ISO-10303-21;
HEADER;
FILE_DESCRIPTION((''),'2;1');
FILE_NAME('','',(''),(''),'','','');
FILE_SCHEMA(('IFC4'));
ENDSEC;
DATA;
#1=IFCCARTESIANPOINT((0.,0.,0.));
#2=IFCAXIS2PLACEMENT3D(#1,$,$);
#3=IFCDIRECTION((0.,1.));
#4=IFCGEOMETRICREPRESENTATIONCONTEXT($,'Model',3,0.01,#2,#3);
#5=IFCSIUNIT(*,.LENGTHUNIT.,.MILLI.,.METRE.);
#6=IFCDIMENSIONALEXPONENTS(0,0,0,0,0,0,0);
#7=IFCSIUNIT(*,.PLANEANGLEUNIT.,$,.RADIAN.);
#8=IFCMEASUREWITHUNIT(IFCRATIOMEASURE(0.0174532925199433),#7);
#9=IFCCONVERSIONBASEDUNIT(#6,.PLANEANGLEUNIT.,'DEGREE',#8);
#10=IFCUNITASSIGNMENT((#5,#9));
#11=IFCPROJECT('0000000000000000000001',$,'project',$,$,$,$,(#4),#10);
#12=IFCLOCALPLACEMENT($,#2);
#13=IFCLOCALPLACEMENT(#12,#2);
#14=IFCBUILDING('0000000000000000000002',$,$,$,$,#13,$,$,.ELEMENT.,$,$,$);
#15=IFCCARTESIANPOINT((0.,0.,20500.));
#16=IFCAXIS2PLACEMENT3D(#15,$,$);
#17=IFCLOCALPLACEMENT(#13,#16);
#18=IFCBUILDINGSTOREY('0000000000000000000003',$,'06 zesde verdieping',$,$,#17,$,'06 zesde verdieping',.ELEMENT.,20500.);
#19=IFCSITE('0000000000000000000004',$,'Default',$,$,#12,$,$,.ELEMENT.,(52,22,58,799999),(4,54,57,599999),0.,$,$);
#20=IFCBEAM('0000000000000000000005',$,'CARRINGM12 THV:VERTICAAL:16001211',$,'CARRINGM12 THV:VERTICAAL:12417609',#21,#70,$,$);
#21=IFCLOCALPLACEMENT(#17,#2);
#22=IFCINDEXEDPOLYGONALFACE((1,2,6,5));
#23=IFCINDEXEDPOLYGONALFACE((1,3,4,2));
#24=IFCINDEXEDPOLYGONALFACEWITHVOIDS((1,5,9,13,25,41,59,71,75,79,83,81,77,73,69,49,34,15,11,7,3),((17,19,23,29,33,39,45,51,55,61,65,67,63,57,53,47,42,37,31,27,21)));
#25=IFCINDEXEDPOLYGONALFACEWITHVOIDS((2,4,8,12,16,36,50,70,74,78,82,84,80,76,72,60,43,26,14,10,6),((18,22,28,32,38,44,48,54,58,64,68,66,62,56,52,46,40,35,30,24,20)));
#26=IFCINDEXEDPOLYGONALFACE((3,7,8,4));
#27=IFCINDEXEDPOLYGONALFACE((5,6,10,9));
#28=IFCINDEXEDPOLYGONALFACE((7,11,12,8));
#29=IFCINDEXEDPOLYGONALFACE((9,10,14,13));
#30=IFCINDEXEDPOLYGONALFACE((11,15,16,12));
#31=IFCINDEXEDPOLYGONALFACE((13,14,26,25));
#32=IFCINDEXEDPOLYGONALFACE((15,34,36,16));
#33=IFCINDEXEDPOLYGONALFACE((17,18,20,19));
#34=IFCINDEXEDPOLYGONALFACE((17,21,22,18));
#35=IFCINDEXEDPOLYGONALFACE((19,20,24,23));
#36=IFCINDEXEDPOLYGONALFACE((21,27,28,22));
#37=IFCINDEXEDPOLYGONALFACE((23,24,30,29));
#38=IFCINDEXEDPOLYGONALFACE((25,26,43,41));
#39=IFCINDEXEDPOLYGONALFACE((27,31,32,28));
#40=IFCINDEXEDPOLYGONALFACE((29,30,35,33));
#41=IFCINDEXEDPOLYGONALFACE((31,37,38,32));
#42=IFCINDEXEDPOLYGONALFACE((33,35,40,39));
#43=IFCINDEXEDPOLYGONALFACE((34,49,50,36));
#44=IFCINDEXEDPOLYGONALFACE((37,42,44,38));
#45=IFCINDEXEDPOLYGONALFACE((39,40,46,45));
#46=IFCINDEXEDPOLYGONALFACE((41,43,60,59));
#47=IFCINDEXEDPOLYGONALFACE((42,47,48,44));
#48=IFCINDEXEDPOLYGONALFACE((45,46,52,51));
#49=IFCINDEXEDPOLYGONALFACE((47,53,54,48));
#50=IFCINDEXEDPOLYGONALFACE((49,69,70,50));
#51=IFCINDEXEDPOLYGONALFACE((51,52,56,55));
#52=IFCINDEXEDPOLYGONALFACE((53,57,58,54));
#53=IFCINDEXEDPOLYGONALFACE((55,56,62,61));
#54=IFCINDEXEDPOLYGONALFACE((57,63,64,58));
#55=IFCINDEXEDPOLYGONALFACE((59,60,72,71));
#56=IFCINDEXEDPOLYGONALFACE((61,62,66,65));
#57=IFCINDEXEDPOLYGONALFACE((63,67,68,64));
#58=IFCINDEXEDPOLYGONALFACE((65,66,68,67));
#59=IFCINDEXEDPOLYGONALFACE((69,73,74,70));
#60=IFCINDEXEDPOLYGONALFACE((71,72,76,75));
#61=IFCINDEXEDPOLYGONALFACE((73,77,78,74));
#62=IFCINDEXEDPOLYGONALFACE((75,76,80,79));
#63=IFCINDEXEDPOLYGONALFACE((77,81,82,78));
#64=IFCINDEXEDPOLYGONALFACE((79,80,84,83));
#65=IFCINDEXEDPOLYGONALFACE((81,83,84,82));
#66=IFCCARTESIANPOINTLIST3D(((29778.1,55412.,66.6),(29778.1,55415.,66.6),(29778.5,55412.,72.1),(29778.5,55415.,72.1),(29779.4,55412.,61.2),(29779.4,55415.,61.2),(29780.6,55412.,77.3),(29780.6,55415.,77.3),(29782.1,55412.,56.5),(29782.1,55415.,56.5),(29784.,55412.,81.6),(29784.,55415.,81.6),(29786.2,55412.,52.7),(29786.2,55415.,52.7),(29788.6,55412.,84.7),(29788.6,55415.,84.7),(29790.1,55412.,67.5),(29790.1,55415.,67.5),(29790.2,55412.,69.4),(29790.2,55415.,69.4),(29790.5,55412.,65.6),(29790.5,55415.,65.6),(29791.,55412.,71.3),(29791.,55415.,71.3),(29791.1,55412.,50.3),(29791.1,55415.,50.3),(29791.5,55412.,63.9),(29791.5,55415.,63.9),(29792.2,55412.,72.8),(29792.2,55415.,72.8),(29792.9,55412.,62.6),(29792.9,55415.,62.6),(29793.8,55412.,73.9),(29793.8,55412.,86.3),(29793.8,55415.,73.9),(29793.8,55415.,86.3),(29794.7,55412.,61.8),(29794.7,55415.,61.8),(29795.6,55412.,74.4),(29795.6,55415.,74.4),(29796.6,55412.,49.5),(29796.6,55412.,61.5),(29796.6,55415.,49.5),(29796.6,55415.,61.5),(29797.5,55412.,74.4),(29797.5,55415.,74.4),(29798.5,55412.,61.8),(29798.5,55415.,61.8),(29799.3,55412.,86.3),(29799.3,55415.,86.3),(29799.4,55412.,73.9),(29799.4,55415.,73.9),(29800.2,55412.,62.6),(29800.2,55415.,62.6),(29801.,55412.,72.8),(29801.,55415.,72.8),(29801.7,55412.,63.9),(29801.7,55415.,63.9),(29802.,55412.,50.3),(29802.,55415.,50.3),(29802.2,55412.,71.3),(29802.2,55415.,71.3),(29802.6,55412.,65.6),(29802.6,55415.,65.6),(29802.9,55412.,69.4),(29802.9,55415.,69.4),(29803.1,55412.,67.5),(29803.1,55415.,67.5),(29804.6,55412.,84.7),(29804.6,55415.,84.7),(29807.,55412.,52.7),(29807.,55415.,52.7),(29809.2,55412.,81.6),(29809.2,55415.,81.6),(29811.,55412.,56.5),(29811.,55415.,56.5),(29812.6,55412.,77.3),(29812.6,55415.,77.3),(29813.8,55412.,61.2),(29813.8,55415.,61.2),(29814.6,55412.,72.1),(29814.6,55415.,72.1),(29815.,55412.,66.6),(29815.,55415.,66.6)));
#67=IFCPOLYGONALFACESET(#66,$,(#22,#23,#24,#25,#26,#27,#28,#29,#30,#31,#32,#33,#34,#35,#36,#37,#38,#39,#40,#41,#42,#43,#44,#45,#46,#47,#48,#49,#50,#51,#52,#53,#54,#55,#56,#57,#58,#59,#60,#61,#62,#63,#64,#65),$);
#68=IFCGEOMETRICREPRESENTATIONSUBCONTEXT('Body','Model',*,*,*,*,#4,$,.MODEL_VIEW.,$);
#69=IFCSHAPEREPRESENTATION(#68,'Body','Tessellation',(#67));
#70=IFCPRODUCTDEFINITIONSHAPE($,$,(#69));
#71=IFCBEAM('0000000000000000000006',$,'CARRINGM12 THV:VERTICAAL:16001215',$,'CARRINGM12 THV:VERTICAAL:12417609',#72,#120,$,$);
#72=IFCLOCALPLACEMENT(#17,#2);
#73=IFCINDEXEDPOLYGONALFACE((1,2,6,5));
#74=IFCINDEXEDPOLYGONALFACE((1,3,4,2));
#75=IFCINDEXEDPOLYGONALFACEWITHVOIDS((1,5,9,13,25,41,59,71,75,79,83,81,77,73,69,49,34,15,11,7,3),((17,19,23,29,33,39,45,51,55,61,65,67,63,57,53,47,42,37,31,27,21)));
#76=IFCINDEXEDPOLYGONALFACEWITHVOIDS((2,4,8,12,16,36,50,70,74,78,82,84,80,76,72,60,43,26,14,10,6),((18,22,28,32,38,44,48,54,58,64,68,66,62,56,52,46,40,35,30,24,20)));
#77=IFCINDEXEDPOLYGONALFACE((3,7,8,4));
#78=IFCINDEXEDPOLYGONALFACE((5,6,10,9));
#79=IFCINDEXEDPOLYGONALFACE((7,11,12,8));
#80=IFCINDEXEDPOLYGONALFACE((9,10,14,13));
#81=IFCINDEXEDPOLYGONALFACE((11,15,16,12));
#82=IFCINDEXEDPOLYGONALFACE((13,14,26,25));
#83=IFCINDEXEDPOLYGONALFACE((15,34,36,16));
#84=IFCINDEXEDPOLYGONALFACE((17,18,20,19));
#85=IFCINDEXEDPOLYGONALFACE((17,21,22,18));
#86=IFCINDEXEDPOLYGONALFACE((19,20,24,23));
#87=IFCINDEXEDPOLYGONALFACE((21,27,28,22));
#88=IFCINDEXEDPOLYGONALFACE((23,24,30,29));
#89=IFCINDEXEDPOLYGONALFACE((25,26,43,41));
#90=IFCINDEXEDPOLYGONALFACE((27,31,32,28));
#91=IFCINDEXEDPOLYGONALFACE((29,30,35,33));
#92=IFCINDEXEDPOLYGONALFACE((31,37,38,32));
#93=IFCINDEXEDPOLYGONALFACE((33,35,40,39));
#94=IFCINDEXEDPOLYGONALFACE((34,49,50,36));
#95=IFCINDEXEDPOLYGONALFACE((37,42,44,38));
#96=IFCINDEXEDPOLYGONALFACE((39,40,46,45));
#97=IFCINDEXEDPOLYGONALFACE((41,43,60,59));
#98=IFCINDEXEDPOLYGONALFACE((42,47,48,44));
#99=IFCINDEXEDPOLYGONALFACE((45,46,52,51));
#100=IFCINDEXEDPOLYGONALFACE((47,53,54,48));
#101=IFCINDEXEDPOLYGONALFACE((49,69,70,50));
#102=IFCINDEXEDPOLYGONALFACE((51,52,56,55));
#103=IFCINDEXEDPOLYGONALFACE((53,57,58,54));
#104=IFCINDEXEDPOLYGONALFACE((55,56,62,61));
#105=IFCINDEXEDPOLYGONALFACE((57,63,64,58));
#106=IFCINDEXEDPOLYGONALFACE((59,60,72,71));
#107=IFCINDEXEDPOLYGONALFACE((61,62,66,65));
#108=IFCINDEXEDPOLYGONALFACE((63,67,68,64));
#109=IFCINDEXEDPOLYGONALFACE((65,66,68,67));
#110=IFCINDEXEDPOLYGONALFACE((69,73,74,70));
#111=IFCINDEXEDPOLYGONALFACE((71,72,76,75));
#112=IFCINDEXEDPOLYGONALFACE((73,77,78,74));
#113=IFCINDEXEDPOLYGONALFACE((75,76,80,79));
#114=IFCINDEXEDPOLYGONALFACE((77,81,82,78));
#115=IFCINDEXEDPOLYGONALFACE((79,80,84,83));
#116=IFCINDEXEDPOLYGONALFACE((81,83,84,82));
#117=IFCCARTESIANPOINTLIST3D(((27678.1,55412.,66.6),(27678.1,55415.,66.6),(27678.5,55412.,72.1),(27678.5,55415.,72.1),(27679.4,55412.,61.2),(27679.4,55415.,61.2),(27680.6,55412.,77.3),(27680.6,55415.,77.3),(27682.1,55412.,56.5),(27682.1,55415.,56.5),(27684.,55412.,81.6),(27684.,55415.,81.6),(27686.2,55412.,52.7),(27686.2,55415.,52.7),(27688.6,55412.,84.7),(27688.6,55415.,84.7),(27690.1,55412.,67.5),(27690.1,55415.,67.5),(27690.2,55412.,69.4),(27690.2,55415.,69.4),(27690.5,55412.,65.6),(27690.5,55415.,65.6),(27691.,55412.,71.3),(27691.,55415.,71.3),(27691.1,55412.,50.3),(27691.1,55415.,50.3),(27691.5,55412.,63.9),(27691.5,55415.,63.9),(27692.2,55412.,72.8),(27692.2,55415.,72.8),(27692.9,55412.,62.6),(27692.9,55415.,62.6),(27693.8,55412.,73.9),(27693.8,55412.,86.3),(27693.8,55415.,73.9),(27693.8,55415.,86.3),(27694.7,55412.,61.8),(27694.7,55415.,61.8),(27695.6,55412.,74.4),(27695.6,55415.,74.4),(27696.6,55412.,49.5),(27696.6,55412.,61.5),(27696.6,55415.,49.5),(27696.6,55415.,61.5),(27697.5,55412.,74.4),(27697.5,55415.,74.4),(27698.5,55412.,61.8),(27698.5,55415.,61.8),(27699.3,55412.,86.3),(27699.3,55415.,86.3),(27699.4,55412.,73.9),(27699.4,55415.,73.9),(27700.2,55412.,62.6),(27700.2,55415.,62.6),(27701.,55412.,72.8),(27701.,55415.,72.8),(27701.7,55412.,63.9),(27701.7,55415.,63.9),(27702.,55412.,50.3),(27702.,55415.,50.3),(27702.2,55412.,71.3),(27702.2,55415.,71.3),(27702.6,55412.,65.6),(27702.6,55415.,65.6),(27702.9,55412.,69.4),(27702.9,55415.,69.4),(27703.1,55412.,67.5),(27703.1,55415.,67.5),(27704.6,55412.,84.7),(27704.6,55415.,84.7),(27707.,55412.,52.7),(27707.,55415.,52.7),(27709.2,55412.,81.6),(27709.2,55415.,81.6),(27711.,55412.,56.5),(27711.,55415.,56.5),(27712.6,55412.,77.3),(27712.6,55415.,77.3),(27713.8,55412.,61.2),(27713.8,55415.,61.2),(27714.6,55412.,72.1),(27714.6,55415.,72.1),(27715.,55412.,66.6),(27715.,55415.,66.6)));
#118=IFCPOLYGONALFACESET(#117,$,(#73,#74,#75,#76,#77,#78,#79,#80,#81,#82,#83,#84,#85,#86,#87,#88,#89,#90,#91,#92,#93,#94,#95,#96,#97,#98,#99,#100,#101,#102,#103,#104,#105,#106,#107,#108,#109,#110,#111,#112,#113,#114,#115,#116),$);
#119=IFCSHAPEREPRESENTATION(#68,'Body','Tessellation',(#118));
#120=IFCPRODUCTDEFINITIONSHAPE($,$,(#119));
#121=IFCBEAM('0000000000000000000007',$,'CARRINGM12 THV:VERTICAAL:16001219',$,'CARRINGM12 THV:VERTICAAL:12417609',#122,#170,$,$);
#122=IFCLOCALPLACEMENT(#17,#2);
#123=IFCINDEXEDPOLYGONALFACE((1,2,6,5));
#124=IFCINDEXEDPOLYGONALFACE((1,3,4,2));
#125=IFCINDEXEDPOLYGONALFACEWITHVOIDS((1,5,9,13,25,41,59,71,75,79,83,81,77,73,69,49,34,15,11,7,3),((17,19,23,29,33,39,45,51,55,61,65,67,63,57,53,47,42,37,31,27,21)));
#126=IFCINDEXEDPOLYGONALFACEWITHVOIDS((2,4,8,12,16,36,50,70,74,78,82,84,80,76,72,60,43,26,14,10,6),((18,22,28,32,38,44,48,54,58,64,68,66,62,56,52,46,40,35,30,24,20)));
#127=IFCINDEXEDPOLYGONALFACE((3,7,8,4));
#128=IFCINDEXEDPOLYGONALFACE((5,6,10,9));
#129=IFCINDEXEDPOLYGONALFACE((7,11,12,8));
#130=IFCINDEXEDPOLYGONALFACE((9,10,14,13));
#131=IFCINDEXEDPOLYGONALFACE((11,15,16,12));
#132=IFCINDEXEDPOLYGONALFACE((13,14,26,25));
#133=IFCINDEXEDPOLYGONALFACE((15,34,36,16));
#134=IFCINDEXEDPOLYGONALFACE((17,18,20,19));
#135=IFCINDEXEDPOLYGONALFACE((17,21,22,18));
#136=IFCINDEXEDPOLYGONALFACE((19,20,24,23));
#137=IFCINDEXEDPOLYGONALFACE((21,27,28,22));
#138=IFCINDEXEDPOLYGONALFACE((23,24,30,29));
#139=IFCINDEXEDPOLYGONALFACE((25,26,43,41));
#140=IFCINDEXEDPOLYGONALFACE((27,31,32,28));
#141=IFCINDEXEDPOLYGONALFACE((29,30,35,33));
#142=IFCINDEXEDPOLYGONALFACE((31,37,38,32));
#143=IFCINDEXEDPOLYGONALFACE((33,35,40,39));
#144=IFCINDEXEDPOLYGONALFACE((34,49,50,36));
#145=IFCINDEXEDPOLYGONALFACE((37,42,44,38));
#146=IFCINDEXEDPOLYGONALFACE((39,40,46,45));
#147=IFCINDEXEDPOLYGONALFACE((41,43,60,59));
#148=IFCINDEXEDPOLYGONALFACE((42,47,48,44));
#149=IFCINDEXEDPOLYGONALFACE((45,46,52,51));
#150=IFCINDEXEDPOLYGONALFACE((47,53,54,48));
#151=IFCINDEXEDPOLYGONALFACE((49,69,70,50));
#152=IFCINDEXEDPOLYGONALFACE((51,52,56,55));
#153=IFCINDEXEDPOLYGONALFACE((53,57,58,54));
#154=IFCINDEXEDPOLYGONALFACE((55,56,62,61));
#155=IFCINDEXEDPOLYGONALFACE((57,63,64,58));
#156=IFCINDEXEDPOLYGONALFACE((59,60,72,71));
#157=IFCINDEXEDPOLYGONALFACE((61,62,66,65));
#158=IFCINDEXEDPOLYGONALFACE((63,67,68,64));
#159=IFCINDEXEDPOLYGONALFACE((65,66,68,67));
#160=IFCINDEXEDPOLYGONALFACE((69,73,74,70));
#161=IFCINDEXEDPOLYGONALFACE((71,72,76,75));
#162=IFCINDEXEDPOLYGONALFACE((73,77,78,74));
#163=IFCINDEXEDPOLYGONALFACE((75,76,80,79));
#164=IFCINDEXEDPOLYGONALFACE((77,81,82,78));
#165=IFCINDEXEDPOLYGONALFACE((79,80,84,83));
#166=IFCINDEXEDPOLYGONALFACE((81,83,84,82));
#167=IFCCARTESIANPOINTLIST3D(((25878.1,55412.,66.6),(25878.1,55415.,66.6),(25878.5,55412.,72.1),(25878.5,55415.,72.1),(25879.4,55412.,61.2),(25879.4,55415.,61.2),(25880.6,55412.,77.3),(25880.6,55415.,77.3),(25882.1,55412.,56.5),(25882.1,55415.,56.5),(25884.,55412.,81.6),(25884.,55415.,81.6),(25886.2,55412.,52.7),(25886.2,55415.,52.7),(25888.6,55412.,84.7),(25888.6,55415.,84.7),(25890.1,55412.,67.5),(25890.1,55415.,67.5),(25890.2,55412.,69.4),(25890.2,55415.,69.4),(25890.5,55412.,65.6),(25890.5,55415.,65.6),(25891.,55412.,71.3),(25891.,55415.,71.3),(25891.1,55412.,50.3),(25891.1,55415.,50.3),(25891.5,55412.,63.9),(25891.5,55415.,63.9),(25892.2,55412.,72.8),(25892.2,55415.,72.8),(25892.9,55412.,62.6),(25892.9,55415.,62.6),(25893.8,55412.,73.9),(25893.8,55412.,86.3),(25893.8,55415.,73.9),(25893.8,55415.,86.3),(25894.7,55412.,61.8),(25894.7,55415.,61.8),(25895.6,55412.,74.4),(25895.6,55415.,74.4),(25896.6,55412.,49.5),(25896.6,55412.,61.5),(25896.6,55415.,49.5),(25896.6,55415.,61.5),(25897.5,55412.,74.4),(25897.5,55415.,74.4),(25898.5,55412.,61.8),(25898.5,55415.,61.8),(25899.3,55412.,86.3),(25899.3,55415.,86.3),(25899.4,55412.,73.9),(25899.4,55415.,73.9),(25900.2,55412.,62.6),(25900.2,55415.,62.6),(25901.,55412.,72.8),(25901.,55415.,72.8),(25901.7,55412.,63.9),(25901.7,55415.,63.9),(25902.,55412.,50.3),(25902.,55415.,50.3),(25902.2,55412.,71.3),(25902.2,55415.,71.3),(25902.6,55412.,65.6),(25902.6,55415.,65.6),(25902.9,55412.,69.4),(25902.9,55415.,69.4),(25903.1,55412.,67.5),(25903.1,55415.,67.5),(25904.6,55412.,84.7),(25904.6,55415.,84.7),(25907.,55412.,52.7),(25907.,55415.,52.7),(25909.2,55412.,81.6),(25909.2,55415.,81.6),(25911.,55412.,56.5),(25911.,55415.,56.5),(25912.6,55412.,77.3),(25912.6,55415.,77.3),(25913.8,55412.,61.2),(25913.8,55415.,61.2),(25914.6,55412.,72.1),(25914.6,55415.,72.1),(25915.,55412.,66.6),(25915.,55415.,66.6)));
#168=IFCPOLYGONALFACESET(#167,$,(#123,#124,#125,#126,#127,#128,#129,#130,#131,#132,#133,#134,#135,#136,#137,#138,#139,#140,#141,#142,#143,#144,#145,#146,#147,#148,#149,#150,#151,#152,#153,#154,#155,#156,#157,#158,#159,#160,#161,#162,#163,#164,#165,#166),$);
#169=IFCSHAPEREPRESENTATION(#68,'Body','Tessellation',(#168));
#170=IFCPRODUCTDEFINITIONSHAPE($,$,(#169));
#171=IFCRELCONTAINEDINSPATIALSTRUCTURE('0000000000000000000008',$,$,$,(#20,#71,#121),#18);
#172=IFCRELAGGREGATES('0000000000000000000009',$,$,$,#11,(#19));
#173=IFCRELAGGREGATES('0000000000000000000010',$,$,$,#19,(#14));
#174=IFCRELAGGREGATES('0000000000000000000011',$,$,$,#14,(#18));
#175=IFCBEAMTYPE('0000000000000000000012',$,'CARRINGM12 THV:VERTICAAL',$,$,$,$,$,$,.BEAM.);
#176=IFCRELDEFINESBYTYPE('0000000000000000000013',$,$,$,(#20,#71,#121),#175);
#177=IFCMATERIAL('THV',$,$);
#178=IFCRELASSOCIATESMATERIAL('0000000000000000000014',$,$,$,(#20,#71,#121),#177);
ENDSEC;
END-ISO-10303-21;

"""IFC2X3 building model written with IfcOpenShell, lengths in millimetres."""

from ifc_helpers import new_model, entity, si_unit, converted_unit, direction, frame, origin, origin_2d_with_axis, place, context, subcontext, project, spatial, hollow_circle, extrude, material, type_object, element, save


model = new_model("IFC2X3")

# Units and contexts
model_context = context("Model", 3, precision=0.01, world=origin(), true_north=direction((0.0, 1.0)))
body_context = subcontext(model_context, "Body", "Model", "MODEL_VIEW")
ifc_project = project(units=[si_unit("LENGTHUNIT", "METRE", prefix="MILLI"), converted_unit("PLANEANGLEUNIT", "DEGREE", entity("IfcRatioMeasure", 0.0174532925199433), si_unit("PLANEANGLEUNIT", "RADIAN"), dimensions=[0, 0, 0, 0, 0, 0, 0])], contexts=[model_context])

# Site, building, storey
site_placement = place(None, origin())
site = spatial("IfcSite", under=ifc_project, at=site_placement, Name="Default", CompositionType="ELEMENT", RefLatitude=(52, 22, 58, 799999), RefLongitude=(4, 54, 57, 599999), RefElevation=0.0)
building_placement = place(site_placement, origin())
building = spatial("IfcBuilding", under=site, at=building_placement, CompositionType="ELEMENT")
storey_placement = place(building_placement, frame((0.0, 0.0, 20500.0)))
storey = spatial("IfcBuildingStorey", under=building, at=storey_placement, Name="06 zesde verdieping", LongName="06 zesde verdieping", CompositionType="ELEMENT", Elevation=20500.0)

# Beams
ifc_material_1 = material(Name="THV")
beam_type_1 = type_object("IfcBeamType", Name="CARRINGM12 THV:VERTICAAL", PredefinedType="BEAM")
beam_1_placement = place(storey_placement, origin())
element("IfcBeam", 1, at=beam_1_placement, inside=storey, type_object=beam_type_1, material=ifc_material_1, Name="CARRINGM12 THV:VERTICAAL:16001211", ObjectType="CARRINGM12 THV:VERTICAAL:12417609", context=body_context, shape_type="SweptSolid", body=[
    extrude(hollow_circle(Radius=18.5, WallThickness=12.0, at=origin_2d_with_axis()), frame((29796.6, 55412.0, 68.0), z_axis=(0.0, 1.0, 0.0), x_axis=(0.0, 0.0, -1.0)), (0.0, 0.0, 1.0), 3.0),
])
beam_2_placement = place(storey_placement, origin())
element("IfcBeam", 2, at=beam_2_placement, inside=storey, type_object=beam_type_1, material=ifc_material_1, Name="CARRINGM12 THV:VERTICAAL:16001215", ObjectType="CARRINGM12 THV:VERTICAAL:12417609", context=body_context, shape_type="SweptSolid", body=[
    extrude(hollow_circle(Radius=18.5, WallThickness=12.0, at=origin_2d_with_axis()), frame((27696.6, 55412.0, 68.0), z_axis=(0.0, 1.0, 0.0), x_axis=(0.0, 0.0, -1.0)), (0.0, 0.0, 1.0), 3.0),
])
beam_3_placement = place(storey_placement, origin())
element("IfcBeam", 3, at=beam_3_placement, inside=storey, type_object=beam_type_1, material=ifc_material_1, Name="CARRINGM12 THV:VERTICAAL:16001219", ObjectType="CARRINGM12 THV:VERTICAAL:12417609", context=body_context, shape_type="SweptSolid", body=[
    extrude(hollow_circle(Radius=18.5, WallThickness=12.0, at=origin_2d_with_axis()), frame((25896.6, 55412.0, 68.0), z_axis=(0.0, 1.0, 0.0), x_axis=(0.0, 0.0, -1.0)), (0.0, 0.0, 1.0), 3.0),
])

save(model, "model.ifc")
